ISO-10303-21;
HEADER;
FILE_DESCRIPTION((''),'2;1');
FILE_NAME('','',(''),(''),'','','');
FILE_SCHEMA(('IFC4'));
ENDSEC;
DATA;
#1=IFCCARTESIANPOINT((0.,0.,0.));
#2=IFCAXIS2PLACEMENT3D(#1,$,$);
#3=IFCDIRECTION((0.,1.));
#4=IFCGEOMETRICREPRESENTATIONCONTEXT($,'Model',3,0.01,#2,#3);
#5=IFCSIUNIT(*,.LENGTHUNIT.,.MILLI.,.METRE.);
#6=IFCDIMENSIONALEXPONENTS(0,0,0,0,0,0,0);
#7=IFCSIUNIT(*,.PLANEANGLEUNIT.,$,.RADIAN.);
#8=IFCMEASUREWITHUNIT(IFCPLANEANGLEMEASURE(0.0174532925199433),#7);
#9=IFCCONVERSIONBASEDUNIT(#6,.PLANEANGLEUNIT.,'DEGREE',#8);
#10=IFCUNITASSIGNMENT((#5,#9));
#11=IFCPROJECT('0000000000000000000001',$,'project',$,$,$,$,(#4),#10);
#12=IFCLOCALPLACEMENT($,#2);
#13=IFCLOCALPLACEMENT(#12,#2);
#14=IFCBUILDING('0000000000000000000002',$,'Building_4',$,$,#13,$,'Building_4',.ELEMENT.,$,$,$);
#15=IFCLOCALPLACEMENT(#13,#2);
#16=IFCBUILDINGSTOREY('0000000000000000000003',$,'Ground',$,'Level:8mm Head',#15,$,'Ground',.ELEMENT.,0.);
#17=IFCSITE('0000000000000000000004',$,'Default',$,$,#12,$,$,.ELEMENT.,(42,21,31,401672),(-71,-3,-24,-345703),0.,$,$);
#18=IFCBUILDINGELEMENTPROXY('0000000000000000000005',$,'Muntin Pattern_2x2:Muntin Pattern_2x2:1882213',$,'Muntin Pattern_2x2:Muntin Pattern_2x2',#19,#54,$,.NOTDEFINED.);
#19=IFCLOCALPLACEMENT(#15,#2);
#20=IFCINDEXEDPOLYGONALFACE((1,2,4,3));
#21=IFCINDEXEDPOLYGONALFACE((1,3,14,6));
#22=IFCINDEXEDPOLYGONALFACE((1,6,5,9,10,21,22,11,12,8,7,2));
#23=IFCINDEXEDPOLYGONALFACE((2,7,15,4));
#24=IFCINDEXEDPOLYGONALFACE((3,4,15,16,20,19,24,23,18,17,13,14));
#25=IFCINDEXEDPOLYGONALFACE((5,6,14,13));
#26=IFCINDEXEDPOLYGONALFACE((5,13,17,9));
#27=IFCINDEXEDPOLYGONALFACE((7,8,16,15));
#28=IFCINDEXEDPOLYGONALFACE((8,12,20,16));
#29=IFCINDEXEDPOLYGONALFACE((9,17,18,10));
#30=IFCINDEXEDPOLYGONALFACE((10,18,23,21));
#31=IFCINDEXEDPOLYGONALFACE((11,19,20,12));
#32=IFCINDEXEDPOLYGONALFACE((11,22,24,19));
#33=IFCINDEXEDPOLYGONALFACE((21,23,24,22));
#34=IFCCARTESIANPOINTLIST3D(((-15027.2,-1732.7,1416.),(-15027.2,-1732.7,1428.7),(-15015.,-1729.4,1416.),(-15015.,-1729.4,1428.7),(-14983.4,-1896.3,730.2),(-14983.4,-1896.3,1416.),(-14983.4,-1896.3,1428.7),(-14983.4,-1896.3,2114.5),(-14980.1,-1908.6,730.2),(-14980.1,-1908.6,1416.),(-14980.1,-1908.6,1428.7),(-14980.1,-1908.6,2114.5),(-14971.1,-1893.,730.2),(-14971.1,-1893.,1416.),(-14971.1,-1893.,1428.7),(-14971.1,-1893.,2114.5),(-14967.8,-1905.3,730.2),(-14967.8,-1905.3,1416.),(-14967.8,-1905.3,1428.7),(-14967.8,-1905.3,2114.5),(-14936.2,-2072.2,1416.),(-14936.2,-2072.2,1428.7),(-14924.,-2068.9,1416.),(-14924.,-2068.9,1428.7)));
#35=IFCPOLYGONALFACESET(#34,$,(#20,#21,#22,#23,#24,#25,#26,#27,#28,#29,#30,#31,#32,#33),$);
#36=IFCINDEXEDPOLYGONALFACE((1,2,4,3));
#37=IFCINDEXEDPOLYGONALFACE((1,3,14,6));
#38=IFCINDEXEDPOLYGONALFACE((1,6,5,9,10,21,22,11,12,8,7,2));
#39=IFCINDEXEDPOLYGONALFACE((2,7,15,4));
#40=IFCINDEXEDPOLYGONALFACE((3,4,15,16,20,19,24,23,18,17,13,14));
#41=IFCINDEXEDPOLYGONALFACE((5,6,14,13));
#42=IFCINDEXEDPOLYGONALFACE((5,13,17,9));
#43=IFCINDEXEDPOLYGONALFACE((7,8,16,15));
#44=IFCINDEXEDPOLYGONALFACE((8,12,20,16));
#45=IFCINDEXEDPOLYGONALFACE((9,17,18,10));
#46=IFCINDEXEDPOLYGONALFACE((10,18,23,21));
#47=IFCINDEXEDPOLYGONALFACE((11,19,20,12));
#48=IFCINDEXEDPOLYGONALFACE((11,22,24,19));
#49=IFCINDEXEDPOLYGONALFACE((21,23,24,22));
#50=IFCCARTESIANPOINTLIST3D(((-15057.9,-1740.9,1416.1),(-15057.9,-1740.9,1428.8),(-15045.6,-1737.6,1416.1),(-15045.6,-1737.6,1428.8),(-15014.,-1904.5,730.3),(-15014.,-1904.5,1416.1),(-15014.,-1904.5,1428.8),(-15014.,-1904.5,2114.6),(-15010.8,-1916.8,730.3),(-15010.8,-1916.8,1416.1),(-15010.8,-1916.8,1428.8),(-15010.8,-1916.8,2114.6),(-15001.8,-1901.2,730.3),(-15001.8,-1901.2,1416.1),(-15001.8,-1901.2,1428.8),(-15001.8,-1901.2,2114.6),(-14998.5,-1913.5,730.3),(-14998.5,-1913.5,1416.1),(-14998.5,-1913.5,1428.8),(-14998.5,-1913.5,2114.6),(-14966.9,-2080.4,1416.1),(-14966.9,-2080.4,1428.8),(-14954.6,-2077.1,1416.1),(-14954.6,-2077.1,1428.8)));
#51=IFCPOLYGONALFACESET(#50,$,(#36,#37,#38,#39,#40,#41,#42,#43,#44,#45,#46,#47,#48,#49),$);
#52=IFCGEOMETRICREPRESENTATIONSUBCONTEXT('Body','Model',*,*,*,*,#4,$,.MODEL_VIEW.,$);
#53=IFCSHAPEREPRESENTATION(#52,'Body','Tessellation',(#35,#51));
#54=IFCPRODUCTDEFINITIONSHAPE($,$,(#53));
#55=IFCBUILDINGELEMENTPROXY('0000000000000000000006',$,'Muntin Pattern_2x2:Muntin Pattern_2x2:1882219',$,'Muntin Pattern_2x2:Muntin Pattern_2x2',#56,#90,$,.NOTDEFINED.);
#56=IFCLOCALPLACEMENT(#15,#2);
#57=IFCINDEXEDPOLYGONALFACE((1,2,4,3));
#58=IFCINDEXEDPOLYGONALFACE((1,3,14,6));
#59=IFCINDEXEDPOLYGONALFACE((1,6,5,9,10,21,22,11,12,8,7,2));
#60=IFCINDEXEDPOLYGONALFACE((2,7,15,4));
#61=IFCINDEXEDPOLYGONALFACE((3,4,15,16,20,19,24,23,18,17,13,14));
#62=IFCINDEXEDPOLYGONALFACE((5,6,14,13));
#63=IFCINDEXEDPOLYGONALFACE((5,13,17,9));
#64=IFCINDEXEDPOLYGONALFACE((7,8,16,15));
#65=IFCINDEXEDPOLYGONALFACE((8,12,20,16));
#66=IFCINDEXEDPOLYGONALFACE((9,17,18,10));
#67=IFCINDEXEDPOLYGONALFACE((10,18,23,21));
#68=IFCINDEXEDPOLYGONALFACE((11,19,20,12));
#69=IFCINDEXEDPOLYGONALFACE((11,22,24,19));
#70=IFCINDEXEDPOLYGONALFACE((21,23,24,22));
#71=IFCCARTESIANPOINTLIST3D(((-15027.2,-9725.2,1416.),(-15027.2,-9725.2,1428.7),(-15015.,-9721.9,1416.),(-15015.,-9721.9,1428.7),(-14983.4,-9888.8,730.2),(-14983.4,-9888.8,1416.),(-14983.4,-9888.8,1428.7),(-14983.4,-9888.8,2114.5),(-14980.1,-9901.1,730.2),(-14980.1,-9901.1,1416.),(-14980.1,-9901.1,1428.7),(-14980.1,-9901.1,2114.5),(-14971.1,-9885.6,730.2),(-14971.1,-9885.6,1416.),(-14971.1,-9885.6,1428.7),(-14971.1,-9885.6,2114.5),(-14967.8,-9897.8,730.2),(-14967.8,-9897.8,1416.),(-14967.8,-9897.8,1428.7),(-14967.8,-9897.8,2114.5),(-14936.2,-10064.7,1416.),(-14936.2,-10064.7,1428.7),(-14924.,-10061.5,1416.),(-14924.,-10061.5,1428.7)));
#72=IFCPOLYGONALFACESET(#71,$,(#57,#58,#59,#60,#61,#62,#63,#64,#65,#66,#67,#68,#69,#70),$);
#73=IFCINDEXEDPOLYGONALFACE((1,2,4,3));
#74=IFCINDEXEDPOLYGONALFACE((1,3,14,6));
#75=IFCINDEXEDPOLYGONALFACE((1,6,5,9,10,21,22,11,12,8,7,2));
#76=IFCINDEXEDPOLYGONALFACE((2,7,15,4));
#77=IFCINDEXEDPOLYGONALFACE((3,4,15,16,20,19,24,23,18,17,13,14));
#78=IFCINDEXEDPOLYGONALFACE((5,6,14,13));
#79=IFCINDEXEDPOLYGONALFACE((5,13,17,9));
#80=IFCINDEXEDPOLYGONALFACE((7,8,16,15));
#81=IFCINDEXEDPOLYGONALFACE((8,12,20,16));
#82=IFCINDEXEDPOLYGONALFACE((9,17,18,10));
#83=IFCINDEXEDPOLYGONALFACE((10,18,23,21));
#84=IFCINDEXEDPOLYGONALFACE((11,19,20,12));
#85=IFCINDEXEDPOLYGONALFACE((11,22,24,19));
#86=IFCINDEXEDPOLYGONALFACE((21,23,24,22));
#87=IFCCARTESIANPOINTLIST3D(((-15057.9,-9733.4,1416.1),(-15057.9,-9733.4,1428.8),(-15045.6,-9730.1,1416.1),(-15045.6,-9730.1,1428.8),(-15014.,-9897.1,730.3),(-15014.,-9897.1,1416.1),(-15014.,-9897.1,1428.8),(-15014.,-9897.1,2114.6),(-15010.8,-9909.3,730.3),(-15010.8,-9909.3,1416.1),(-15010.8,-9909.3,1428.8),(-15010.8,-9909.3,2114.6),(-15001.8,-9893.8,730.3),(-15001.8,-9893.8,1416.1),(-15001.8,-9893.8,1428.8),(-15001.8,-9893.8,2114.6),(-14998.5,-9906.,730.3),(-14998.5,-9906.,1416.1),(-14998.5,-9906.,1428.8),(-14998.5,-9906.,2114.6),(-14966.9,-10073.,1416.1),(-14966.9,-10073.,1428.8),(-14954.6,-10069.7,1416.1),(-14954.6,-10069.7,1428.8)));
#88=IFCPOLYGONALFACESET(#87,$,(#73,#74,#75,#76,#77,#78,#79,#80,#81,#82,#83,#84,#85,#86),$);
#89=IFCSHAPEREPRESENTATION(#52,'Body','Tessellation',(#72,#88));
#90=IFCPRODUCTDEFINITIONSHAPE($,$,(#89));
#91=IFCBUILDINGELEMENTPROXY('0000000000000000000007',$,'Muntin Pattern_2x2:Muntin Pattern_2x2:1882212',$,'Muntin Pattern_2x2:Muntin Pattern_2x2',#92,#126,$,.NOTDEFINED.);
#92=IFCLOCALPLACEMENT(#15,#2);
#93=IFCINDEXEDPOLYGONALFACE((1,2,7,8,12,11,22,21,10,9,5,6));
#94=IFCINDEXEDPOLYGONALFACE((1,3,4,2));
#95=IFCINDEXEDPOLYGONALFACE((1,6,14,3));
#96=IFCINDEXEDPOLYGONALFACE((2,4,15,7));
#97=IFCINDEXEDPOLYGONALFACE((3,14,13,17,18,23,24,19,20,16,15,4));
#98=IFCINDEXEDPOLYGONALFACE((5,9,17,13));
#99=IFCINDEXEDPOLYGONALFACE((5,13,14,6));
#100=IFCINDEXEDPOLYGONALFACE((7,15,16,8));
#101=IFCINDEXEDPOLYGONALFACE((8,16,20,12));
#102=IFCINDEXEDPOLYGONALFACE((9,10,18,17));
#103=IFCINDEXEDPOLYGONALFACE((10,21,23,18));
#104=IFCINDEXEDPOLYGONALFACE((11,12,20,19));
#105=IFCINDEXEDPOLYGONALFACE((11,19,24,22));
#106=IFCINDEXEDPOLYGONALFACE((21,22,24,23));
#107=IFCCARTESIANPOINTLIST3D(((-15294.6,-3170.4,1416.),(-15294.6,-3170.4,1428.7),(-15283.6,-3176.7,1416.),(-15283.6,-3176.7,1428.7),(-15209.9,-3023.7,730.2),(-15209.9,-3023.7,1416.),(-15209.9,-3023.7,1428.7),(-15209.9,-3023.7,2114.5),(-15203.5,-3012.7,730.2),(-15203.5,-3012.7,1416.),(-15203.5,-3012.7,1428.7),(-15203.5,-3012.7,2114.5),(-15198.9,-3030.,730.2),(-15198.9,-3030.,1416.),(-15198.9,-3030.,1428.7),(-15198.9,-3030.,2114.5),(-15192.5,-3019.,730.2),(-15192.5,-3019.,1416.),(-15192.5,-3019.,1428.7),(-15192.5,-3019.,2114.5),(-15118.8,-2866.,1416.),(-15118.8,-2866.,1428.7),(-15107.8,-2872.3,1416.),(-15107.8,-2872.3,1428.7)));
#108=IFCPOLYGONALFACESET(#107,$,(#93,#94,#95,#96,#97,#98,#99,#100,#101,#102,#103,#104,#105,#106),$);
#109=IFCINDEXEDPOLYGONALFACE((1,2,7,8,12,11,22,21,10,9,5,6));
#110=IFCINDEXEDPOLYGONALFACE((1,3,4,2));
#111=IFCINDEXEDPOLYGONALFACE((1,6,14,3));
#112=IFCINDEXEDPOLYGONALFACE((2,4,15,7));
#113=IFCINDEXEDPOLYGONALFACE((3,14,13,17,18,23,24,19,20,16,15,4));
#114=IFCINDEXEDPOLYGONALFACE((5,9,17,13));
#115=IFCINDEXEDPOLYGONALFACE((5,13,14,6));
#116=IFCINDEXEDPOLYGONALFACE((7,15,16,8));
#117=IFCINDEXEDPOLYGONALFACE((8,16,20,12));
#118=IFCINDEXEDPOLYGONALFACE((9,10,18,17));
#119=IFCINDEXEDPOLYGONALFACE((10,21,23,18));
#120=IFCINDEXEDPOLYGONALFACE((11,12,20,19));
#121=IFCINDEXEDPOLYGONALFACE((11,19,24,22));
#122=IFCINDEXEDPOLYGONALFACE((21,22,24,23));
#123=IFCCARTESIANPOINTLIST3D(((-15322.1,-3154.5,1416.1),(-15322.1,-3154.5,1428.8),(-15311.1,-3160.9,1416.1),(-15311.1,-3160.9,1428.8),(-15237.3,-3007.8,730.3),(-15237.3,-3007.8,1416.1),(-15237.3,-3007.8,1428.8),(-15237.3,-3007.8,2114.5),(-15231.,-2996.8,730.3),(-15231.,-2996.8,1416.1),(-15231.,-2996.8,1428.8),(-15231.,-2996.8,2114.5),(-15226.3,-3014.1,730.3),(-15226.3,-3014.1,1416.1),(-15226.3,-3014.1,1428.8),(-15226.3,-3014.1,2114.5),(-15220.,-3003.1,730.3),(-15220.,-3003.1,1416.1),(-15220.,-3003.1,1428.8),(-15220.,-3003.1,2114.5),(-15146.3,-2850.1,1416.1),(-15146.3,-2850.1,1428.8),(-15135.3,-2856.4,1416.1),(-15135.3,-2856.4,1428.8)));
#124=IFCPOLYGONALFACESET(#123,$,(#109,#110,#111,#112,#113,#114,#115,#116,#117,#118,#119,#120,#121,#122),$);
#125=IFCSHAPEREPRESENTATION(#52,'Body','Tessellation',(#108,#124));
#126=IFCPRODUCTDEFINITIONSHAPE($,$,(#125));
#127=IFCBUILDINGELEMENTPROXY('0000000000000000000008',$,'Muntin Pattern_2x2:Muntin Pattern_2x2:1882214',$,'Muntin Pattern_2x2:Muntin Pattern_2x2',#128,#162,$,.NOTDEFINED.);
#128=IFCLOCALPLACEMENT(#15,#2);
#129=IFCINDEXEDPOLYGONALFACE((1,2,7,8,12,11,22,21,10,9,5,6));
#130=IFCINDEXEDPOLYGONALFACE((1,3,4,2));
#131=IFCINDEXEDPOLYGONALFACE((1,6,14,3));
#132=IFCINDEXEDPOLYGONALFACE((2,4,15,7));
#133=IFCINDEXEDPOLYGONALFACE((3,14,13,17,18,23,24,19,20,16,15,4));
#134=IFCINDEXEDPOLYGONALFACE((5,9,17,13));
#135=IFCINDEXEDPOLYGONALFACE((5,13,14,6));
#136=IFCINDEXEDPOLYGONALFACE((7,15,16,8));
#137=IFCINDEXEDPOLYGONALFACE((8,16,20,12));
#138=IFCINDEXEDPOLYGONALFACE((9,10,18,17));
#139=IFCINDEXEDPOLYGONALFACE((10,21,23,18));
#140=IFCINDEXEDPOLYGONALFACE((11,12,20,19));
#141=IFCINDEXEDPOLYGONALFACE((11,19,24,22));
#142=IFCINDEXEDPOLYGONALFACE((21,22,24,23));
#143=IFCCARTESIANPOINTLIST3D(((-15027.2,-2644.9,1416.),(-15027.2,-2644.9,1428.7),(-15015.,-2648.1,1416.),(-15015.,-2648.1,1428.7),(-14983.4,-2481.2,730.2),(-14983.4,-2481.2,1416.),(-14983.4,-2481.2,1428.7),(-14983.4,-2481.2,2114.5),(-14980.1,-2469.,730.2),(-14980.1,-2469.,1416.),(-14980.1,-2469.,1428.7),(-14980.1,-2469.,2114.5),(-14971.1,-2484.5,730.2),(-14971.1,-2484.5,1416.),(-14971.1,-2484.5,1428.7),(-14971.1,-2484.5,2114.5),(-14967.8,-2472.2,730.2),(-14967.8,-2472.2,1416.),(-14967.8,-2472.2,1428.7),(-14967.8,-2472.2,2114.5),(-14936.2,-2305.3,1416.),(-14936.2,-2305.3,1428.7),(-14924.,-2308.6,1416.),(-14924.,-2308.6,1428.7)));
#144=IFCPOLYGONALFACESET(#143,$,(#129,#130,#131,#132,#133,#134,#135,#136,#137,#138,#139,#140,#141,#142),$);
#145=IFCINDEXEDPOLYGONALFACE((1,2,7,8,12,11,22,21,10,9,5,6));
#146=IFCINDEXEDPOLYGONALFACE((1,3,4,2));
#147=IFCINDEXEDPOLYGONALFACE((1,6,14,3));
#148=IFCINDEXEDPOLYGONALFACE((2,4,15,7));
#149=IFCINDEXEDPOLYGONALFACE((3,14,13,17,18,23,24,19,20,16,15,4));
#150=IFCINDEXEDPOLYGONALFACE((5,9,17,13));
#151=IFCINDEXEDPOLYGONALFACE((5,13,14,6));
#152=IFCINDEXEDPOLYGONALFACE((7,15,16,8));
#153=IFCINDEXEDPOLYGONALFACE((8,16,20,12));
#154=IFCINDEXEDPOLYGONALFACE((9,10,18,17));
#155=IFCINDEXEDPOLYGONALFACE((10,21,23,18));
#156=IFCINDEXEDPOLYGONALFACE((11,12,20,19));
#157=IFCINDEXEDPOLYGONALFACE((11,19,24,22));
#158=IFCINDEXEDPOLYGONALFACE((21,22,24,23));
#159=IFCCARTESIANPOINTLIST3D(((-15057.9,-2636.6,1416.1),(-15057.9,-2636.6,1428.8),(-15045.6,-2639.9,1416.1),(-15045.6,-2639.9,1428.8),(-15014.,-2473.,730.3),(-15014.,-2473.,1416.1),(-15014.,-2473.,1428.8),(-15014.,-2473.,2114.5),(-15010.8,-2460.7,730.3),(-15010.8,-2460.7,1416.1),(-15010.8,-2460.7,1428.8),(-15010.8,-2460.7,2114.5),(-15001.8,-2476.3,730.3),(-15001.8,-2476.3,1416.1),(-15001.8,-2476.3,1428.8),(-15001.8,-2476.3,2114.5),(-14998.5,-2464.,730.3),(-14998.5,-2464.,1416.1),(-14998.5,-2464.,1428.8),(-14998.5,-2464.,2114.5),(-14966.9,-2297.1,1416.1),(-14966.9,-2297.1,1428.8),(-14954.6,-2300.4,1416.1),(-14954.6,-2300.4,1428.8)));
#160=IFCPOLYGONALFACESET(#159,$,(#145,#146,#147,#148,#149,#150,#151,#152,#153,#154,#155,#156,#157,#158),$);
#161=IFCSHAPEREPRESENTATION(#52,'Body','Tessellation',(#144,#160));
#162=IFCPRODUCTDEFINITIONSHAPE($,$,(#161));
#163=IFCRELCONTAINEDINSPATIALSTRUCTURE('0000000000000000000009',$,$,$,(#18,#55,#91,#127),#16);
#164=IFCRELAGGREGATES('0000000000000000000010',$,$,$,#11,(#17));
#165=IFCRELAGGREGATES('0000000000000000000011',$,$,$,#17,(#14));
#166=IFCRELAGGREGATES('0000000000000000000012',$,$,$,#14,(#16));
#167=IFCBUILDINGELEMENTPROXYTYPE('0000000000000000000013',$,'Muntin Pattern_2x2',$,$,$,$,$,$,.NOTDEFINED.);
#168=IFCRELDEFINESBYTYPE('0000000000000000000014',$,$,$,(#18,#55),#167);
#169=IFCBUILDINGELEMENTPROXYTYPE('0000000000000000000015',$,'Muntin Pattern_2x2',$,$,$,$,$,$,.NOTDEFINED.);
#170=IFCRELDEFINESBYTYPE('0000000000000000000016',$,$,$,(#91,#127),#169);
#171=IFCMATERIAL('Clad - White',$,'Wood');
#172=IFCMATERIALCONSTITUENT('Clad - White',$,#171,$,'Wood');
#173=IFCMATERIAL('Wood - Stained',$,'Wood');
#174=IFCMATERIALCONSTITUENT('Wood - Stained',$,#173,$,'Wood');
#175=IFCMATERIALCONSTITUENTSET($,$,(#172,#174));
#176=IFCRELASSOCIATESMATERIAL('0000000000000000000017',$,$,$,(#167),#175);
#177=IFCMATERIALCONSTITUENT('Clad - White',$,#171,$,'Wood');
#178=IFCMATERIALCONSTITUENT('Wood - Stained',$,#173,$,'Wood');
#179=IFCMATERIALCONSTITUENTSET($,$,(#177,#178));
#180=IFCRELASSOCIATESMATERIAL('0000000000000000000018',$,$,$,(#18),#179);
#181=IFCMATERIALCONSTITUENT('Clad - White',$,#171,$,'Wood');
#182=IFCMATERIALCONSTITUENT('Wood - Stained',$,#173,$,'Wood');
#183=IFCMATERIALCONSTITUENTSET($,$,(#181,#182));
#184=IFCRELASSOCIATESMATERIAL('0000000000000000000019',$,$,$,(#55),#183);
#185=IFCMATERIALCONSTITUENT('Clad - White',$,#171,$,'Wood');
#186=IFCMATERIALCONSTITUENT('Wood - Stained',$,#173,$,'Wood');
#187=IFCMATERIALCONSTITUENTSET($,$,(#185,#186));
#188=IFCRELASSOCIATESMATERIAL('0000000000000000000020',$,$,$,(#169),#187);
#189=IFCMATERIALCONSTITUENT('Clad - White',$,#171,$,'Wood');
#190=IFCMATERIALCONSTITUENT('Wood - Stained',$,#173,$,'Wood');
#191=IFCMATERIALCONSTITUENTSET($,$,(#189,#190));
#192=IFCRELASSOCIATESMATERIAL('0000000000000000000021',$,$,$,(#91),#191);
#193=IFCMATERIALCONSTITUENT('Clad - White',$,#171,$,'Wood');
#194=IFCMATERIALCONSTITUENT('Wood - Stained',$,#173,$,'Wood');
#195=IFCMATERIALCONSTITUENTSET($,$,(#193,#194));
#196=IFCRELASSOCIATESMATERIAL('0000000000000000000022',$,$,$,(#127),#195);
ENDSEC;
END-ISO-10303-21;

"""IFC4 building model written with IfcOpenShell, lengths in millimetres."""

from ifc_helpers import new_model, entity, si_unit, converted_unit, direction, frame, origin, place, context, subcontext, project, spatial, indexed_curve, outline, extrude, source, transform, mapped, material, constituent, constituent_set, type_object, type_shapes, element, save


model = new_model("IFC4")

# Units and contexts
model_context = context("Model", 3, precision=0.01, world=origin(), true_north=direction((0.0, 1.0)))
body_context = subcontext(model_context, "Body", "Model", "MODEL_VIEW")
ifc_project = project(units=[si_unit("LENGTHUNIT", "METRE", prefix="MILLI"), converted_unit("PLANEANGLEUNIT", "DEGREE", entity("IfcPlaneAngleMeasure", 0.0174532925199433), si_unit("PLANEANGLEUNIT", "RADIAN"), dimensions=[0, 0, 0, 0, 0, 0, 0])], contexts=[model_context])

# Site, building, storey
site_placement = place(None, origin())
site = spatial("IfcSite", under=ifc_project, at=site_placement, Name="Default", CompositionType="ELEMENT", RefLatitude=(42, 21, 31, 401672), RefLongitude=(-71, -3, -24, -345703), RefElevation=0.0)
building_placement = place(site_placement, origin())
building = spatial("IfcBuilding", under=site, at=building_placement, Name="Building_4", LongName="Building_4", CompositionType="ELEMENT")
storey_placement = place(building_placement, origin())
storey = spatial("IfcBuildingStorey", under=building, at=storey_placement, Name="Ground", ObjectType="Level:8mm Head", LongName="Ground", CompositionType="ELEMENT", Elevation=0.0)

# Building element proxies
ifc_material_1 = material(Name="Clad - White", Category="Wood")
ifc_material_2 = material(Name="Wood - Stained", Category="Wood")
ifc_constituent_1 = constituent(ifc_material_1, Name="Clad - White", Category="Wood")
ifc_constituent_2 = constituent(ifc_material_2, Name="Wood - Stained", Category="Wood")
ifc_constituent_set_1 = constituent_set(constituents=[ifc_constituent_1, ifc_constituent_2])
building_element_proxy_type_1 = type_object("IfcBuildingElementProxyType", Name="Muntin Pattern_2x2", PredefinedType="NOTDEFINED", material=ifc_constituent_set_1)
shared_shape_1 = source(origin(), body_context, "Body", "SweptSolid", [
    extrude(outline(indexed_curve([(6.4, -6.4), (692.1, -6.4), (692.1, 6.3), (6.4, 6.3), (6.4, 175.8), (-6.3, 175.8), (-6.3, 6.3), (-692.2, 6.3), (-692.2, -6.4), (-6.3, -6.4), (-6.3, -175.8), (6.4, -175.8), (6.4, -6.4)], self_intersect=False)), frame((0.0, 9.5, 692.1), z_axis=(0.0, 1.0, 0.0), x_axis=(0.0, 0.0, 1.0)), (0.0, 0.0, 1.0), 12.7),
    extrude(outline(indexed_curve([(6.4, -6.4), (692.1, -6.4), (692.1, 6.3), (6.4, 6.3), (6.4, 175.8), (-6.3, 175.8), (-6.3, 6.3), (-692.2, 6.3), (-692.2, -6.4), (-6.3, -6.4), (-6.3, -175.8), (6.4, -175.8), (6.4, -6.4)], self_intersect=False)), frame((0.0, -22.2, 692.2), z_axis=(0.0, 1.0, 0.0), x_axis=(0.0, 0.0, 1.0)), (0.0, 0.0, 1.0), 12.7),
])
type_shapes(building_element_proxy_type_1, [shared_shape_1])
ifc_constituent_3 = constituent(ifc_material_1, Name="Clad - White", Category="Wood")
ifc_constituent_4 = constituent(ifc_material_2, Name="Wood - Stained", Category="Wood")
ifc_constituent_set_2 = constituent_set(constituents=[ifc_constituent_3, ifc_constituent_4])
proxy_1_placement = place(storey_placement, frame((-14990.9, -1904.9, 730.3), z_axis=(0.0, 0.0, 1.0), x_axis=(0.258819, -0.965926, 0.0)))
element("IfcBuildingElementProxy", 1, at=proxy_1_placement, inside=storey, type_object=building_element_proxy_type_1, material=ifc_constituent_set_2, Name="Muntin Pattern_2x2:Muntin Pattern_2x2:1882213", ObjectType="Muntin Pattern_2x2:Muntin Pattern_2x2", PredefinedType="NOTDEFINED", context=body_context, shape_type="MappedRepresentation", body=[
    mapped(shared_shape_1, transform((0.0, 0.0, 0.0), scale=1.0)),
])
ifc_constituent_5 = constituent(ifc_material_1, Name="Clad - White", Category="Wood")
ifc_constituent_6 = constituent(ifc_material_2, Name="Wood - Stained", Category="Wood")
ifc_constituent_set_3 = constituent_set(constituents=[ifc_constituent_5, ifc_constituent_6])
proxy_2_placement = place(storey_placement, frame((-14990.9, -9897.4, 730.3), z_axis=(0.0, 0.0, 1.0), x_axis=(0.258819, -0.965926, 0.0)))
element("IfcBuildingElementProxy", 2, at=proxy_2_placement, inside=storey, type_object=building_element_proxy_type_1, material=ifc_constituent_set_3, Name="Muntin Pattern_2x2:Muntin Pattern_2x2:1882219", ObjectType="Muntin Pattern_2x2:Muntin Pattern_2x2", PredefinedType="NOTDEFINED", context=body_context, shape_type="MappedRepresentation", body=[
    mapped(shared_shape_1, transform((0.0, 0.0, 0.0), scale=1.0)),
])
ifc_constituent_7 = constituent(ifc_material_1, Name="Clad - White", Category="Wood")
ifc_constituent_8 = constituent(ifc_material_2, Name="Wood - Stained", Category="Wood")
ifc_constituent_set_4 = constituent_set(constituents=[ifc_constituent_7, ifc_constituent_8])
ifc_constituent_9 = constituent(ifc_material_1, Name="Clad - White", Category="Wood")
ifc_constituent_10 = constituent(ifc_material_2, Name="Wood - Stained", Category="Wood")
ifc_constituent_set_5 = constituent_set(constituents=[ifc_constituent_9, ifc_constituent_10])
building_element_proxy_type_2 = type_object("IfcBuildingElementProxyType", Name="Muntin Pattern_2x2", PredefinedType="NOTDEFINED", material=ifc_constituent_set_5)
shared_shape_2 = source(origin(), body_context, "Body", "SweptSolid", [
    extrude(outline(indexed_curve([(6.4, -6.4), (692.1, -6.4), (692.1, 6.3), (6.4, 6.3), (6.4, 175.8), (-6.3, 175.8), (-6.3, 6.3), (-692.2, 6.3), (-692.2, -6.4), (-6.3, -6.4), (-6.3, -175.8), (6.4, -175.8), (6.4, -6.4)], self_intersect=False)), frame((0.0, -22.2, 692.1), z_axis=(0.0, 1.0, 0.0), x_axis=(0.0, 0.0, 1.0)), (0.0, 0.0, 1.0), 12.7),
    extrude(outline(indexed_curve([(6.4, -6.4), (692.1, -6.4), (692.1, 6.3), (6.4, 6.3), (6.4, 175.8), (-6.3, 175.8), (-6.3, 6.3), (-692.1, 6.3), (-692.1, -6.4), (-6.3, -6.4), (-6.3, -175.8), (6.4, -175.8), (6.4, -6.4)], self_intersect=False)), frame((0.0, 9.5, 692.1), z_axis=(0.0, 1.0, 0.0), x_axis=(0.0, 0.0, 1.0)), (0.0, 0.0, 1.0), 12.7),
])
type_shapes(building_element_proxy_type_2, [shared_shape_2])
proxy_3_placement = place(storey_placement, frame((-15214.9, -3013.4, 730.3), z_axis=(0.0, 0.0, 1.0), x_axis=(0.5, 0.866025, 0.0)))
element("IfcBuildingElementProxy", 3, at=proxy_3_placement, inside=storey, type_object=building_element_proxy_type_2, material=ifc_constituent_set_4, Name="Muntin Pattern_2x2:Muntin Pattern_2x2:1882212", ObjectType="Muntin Pattern_2x2:Muntin Pattern_2x2", PredefinedType="NOTDEFINED", context=body_context, shape_type="MappedRepresentation", body=[
    mapped(shared_shape_2, transform((0.0, 0.0, 0.0), scale=1.0)),
])
ifc_constituent_11 = constituent(ifc_material_1, Name="Clad - White", Category="Wood")
ifc_constituent_12 = constituent(ifc_material_2, Name="Wood - Stained", Category="Wood")
ifc_constituent_set_6 = constituent_set(constituents=[ifc_constituent_11, ifc_constituent_12])
proxy_4_placement = place(storey_placement, frame((-14990.9, -2472.6, 730.3), z_axis=(0.0, 0.0, 1.0), x_axis=(0.258819, 0.965926, 0.0)))
element("IfcBuildingElementProxy", 4, at=proxy_4_placement, inside=storey, type_object=building_element_proxy_type_2, material=ifc_constituent_set_6, Name="Muntin Pattern_2x2:Muntin Pattern_2x2:1882214", ObjectType="Muntin Pattern_2x2:Muntin Pattern_2x2", PredefinedType="NOTDEFINED", context=body_context, shape_type="MappedRepresentation", body=[
    mapped(shared_shape_2, transform((0.0, 0.0, 0.0), scale=1.0)),
])

save(model, "model.ifc")
